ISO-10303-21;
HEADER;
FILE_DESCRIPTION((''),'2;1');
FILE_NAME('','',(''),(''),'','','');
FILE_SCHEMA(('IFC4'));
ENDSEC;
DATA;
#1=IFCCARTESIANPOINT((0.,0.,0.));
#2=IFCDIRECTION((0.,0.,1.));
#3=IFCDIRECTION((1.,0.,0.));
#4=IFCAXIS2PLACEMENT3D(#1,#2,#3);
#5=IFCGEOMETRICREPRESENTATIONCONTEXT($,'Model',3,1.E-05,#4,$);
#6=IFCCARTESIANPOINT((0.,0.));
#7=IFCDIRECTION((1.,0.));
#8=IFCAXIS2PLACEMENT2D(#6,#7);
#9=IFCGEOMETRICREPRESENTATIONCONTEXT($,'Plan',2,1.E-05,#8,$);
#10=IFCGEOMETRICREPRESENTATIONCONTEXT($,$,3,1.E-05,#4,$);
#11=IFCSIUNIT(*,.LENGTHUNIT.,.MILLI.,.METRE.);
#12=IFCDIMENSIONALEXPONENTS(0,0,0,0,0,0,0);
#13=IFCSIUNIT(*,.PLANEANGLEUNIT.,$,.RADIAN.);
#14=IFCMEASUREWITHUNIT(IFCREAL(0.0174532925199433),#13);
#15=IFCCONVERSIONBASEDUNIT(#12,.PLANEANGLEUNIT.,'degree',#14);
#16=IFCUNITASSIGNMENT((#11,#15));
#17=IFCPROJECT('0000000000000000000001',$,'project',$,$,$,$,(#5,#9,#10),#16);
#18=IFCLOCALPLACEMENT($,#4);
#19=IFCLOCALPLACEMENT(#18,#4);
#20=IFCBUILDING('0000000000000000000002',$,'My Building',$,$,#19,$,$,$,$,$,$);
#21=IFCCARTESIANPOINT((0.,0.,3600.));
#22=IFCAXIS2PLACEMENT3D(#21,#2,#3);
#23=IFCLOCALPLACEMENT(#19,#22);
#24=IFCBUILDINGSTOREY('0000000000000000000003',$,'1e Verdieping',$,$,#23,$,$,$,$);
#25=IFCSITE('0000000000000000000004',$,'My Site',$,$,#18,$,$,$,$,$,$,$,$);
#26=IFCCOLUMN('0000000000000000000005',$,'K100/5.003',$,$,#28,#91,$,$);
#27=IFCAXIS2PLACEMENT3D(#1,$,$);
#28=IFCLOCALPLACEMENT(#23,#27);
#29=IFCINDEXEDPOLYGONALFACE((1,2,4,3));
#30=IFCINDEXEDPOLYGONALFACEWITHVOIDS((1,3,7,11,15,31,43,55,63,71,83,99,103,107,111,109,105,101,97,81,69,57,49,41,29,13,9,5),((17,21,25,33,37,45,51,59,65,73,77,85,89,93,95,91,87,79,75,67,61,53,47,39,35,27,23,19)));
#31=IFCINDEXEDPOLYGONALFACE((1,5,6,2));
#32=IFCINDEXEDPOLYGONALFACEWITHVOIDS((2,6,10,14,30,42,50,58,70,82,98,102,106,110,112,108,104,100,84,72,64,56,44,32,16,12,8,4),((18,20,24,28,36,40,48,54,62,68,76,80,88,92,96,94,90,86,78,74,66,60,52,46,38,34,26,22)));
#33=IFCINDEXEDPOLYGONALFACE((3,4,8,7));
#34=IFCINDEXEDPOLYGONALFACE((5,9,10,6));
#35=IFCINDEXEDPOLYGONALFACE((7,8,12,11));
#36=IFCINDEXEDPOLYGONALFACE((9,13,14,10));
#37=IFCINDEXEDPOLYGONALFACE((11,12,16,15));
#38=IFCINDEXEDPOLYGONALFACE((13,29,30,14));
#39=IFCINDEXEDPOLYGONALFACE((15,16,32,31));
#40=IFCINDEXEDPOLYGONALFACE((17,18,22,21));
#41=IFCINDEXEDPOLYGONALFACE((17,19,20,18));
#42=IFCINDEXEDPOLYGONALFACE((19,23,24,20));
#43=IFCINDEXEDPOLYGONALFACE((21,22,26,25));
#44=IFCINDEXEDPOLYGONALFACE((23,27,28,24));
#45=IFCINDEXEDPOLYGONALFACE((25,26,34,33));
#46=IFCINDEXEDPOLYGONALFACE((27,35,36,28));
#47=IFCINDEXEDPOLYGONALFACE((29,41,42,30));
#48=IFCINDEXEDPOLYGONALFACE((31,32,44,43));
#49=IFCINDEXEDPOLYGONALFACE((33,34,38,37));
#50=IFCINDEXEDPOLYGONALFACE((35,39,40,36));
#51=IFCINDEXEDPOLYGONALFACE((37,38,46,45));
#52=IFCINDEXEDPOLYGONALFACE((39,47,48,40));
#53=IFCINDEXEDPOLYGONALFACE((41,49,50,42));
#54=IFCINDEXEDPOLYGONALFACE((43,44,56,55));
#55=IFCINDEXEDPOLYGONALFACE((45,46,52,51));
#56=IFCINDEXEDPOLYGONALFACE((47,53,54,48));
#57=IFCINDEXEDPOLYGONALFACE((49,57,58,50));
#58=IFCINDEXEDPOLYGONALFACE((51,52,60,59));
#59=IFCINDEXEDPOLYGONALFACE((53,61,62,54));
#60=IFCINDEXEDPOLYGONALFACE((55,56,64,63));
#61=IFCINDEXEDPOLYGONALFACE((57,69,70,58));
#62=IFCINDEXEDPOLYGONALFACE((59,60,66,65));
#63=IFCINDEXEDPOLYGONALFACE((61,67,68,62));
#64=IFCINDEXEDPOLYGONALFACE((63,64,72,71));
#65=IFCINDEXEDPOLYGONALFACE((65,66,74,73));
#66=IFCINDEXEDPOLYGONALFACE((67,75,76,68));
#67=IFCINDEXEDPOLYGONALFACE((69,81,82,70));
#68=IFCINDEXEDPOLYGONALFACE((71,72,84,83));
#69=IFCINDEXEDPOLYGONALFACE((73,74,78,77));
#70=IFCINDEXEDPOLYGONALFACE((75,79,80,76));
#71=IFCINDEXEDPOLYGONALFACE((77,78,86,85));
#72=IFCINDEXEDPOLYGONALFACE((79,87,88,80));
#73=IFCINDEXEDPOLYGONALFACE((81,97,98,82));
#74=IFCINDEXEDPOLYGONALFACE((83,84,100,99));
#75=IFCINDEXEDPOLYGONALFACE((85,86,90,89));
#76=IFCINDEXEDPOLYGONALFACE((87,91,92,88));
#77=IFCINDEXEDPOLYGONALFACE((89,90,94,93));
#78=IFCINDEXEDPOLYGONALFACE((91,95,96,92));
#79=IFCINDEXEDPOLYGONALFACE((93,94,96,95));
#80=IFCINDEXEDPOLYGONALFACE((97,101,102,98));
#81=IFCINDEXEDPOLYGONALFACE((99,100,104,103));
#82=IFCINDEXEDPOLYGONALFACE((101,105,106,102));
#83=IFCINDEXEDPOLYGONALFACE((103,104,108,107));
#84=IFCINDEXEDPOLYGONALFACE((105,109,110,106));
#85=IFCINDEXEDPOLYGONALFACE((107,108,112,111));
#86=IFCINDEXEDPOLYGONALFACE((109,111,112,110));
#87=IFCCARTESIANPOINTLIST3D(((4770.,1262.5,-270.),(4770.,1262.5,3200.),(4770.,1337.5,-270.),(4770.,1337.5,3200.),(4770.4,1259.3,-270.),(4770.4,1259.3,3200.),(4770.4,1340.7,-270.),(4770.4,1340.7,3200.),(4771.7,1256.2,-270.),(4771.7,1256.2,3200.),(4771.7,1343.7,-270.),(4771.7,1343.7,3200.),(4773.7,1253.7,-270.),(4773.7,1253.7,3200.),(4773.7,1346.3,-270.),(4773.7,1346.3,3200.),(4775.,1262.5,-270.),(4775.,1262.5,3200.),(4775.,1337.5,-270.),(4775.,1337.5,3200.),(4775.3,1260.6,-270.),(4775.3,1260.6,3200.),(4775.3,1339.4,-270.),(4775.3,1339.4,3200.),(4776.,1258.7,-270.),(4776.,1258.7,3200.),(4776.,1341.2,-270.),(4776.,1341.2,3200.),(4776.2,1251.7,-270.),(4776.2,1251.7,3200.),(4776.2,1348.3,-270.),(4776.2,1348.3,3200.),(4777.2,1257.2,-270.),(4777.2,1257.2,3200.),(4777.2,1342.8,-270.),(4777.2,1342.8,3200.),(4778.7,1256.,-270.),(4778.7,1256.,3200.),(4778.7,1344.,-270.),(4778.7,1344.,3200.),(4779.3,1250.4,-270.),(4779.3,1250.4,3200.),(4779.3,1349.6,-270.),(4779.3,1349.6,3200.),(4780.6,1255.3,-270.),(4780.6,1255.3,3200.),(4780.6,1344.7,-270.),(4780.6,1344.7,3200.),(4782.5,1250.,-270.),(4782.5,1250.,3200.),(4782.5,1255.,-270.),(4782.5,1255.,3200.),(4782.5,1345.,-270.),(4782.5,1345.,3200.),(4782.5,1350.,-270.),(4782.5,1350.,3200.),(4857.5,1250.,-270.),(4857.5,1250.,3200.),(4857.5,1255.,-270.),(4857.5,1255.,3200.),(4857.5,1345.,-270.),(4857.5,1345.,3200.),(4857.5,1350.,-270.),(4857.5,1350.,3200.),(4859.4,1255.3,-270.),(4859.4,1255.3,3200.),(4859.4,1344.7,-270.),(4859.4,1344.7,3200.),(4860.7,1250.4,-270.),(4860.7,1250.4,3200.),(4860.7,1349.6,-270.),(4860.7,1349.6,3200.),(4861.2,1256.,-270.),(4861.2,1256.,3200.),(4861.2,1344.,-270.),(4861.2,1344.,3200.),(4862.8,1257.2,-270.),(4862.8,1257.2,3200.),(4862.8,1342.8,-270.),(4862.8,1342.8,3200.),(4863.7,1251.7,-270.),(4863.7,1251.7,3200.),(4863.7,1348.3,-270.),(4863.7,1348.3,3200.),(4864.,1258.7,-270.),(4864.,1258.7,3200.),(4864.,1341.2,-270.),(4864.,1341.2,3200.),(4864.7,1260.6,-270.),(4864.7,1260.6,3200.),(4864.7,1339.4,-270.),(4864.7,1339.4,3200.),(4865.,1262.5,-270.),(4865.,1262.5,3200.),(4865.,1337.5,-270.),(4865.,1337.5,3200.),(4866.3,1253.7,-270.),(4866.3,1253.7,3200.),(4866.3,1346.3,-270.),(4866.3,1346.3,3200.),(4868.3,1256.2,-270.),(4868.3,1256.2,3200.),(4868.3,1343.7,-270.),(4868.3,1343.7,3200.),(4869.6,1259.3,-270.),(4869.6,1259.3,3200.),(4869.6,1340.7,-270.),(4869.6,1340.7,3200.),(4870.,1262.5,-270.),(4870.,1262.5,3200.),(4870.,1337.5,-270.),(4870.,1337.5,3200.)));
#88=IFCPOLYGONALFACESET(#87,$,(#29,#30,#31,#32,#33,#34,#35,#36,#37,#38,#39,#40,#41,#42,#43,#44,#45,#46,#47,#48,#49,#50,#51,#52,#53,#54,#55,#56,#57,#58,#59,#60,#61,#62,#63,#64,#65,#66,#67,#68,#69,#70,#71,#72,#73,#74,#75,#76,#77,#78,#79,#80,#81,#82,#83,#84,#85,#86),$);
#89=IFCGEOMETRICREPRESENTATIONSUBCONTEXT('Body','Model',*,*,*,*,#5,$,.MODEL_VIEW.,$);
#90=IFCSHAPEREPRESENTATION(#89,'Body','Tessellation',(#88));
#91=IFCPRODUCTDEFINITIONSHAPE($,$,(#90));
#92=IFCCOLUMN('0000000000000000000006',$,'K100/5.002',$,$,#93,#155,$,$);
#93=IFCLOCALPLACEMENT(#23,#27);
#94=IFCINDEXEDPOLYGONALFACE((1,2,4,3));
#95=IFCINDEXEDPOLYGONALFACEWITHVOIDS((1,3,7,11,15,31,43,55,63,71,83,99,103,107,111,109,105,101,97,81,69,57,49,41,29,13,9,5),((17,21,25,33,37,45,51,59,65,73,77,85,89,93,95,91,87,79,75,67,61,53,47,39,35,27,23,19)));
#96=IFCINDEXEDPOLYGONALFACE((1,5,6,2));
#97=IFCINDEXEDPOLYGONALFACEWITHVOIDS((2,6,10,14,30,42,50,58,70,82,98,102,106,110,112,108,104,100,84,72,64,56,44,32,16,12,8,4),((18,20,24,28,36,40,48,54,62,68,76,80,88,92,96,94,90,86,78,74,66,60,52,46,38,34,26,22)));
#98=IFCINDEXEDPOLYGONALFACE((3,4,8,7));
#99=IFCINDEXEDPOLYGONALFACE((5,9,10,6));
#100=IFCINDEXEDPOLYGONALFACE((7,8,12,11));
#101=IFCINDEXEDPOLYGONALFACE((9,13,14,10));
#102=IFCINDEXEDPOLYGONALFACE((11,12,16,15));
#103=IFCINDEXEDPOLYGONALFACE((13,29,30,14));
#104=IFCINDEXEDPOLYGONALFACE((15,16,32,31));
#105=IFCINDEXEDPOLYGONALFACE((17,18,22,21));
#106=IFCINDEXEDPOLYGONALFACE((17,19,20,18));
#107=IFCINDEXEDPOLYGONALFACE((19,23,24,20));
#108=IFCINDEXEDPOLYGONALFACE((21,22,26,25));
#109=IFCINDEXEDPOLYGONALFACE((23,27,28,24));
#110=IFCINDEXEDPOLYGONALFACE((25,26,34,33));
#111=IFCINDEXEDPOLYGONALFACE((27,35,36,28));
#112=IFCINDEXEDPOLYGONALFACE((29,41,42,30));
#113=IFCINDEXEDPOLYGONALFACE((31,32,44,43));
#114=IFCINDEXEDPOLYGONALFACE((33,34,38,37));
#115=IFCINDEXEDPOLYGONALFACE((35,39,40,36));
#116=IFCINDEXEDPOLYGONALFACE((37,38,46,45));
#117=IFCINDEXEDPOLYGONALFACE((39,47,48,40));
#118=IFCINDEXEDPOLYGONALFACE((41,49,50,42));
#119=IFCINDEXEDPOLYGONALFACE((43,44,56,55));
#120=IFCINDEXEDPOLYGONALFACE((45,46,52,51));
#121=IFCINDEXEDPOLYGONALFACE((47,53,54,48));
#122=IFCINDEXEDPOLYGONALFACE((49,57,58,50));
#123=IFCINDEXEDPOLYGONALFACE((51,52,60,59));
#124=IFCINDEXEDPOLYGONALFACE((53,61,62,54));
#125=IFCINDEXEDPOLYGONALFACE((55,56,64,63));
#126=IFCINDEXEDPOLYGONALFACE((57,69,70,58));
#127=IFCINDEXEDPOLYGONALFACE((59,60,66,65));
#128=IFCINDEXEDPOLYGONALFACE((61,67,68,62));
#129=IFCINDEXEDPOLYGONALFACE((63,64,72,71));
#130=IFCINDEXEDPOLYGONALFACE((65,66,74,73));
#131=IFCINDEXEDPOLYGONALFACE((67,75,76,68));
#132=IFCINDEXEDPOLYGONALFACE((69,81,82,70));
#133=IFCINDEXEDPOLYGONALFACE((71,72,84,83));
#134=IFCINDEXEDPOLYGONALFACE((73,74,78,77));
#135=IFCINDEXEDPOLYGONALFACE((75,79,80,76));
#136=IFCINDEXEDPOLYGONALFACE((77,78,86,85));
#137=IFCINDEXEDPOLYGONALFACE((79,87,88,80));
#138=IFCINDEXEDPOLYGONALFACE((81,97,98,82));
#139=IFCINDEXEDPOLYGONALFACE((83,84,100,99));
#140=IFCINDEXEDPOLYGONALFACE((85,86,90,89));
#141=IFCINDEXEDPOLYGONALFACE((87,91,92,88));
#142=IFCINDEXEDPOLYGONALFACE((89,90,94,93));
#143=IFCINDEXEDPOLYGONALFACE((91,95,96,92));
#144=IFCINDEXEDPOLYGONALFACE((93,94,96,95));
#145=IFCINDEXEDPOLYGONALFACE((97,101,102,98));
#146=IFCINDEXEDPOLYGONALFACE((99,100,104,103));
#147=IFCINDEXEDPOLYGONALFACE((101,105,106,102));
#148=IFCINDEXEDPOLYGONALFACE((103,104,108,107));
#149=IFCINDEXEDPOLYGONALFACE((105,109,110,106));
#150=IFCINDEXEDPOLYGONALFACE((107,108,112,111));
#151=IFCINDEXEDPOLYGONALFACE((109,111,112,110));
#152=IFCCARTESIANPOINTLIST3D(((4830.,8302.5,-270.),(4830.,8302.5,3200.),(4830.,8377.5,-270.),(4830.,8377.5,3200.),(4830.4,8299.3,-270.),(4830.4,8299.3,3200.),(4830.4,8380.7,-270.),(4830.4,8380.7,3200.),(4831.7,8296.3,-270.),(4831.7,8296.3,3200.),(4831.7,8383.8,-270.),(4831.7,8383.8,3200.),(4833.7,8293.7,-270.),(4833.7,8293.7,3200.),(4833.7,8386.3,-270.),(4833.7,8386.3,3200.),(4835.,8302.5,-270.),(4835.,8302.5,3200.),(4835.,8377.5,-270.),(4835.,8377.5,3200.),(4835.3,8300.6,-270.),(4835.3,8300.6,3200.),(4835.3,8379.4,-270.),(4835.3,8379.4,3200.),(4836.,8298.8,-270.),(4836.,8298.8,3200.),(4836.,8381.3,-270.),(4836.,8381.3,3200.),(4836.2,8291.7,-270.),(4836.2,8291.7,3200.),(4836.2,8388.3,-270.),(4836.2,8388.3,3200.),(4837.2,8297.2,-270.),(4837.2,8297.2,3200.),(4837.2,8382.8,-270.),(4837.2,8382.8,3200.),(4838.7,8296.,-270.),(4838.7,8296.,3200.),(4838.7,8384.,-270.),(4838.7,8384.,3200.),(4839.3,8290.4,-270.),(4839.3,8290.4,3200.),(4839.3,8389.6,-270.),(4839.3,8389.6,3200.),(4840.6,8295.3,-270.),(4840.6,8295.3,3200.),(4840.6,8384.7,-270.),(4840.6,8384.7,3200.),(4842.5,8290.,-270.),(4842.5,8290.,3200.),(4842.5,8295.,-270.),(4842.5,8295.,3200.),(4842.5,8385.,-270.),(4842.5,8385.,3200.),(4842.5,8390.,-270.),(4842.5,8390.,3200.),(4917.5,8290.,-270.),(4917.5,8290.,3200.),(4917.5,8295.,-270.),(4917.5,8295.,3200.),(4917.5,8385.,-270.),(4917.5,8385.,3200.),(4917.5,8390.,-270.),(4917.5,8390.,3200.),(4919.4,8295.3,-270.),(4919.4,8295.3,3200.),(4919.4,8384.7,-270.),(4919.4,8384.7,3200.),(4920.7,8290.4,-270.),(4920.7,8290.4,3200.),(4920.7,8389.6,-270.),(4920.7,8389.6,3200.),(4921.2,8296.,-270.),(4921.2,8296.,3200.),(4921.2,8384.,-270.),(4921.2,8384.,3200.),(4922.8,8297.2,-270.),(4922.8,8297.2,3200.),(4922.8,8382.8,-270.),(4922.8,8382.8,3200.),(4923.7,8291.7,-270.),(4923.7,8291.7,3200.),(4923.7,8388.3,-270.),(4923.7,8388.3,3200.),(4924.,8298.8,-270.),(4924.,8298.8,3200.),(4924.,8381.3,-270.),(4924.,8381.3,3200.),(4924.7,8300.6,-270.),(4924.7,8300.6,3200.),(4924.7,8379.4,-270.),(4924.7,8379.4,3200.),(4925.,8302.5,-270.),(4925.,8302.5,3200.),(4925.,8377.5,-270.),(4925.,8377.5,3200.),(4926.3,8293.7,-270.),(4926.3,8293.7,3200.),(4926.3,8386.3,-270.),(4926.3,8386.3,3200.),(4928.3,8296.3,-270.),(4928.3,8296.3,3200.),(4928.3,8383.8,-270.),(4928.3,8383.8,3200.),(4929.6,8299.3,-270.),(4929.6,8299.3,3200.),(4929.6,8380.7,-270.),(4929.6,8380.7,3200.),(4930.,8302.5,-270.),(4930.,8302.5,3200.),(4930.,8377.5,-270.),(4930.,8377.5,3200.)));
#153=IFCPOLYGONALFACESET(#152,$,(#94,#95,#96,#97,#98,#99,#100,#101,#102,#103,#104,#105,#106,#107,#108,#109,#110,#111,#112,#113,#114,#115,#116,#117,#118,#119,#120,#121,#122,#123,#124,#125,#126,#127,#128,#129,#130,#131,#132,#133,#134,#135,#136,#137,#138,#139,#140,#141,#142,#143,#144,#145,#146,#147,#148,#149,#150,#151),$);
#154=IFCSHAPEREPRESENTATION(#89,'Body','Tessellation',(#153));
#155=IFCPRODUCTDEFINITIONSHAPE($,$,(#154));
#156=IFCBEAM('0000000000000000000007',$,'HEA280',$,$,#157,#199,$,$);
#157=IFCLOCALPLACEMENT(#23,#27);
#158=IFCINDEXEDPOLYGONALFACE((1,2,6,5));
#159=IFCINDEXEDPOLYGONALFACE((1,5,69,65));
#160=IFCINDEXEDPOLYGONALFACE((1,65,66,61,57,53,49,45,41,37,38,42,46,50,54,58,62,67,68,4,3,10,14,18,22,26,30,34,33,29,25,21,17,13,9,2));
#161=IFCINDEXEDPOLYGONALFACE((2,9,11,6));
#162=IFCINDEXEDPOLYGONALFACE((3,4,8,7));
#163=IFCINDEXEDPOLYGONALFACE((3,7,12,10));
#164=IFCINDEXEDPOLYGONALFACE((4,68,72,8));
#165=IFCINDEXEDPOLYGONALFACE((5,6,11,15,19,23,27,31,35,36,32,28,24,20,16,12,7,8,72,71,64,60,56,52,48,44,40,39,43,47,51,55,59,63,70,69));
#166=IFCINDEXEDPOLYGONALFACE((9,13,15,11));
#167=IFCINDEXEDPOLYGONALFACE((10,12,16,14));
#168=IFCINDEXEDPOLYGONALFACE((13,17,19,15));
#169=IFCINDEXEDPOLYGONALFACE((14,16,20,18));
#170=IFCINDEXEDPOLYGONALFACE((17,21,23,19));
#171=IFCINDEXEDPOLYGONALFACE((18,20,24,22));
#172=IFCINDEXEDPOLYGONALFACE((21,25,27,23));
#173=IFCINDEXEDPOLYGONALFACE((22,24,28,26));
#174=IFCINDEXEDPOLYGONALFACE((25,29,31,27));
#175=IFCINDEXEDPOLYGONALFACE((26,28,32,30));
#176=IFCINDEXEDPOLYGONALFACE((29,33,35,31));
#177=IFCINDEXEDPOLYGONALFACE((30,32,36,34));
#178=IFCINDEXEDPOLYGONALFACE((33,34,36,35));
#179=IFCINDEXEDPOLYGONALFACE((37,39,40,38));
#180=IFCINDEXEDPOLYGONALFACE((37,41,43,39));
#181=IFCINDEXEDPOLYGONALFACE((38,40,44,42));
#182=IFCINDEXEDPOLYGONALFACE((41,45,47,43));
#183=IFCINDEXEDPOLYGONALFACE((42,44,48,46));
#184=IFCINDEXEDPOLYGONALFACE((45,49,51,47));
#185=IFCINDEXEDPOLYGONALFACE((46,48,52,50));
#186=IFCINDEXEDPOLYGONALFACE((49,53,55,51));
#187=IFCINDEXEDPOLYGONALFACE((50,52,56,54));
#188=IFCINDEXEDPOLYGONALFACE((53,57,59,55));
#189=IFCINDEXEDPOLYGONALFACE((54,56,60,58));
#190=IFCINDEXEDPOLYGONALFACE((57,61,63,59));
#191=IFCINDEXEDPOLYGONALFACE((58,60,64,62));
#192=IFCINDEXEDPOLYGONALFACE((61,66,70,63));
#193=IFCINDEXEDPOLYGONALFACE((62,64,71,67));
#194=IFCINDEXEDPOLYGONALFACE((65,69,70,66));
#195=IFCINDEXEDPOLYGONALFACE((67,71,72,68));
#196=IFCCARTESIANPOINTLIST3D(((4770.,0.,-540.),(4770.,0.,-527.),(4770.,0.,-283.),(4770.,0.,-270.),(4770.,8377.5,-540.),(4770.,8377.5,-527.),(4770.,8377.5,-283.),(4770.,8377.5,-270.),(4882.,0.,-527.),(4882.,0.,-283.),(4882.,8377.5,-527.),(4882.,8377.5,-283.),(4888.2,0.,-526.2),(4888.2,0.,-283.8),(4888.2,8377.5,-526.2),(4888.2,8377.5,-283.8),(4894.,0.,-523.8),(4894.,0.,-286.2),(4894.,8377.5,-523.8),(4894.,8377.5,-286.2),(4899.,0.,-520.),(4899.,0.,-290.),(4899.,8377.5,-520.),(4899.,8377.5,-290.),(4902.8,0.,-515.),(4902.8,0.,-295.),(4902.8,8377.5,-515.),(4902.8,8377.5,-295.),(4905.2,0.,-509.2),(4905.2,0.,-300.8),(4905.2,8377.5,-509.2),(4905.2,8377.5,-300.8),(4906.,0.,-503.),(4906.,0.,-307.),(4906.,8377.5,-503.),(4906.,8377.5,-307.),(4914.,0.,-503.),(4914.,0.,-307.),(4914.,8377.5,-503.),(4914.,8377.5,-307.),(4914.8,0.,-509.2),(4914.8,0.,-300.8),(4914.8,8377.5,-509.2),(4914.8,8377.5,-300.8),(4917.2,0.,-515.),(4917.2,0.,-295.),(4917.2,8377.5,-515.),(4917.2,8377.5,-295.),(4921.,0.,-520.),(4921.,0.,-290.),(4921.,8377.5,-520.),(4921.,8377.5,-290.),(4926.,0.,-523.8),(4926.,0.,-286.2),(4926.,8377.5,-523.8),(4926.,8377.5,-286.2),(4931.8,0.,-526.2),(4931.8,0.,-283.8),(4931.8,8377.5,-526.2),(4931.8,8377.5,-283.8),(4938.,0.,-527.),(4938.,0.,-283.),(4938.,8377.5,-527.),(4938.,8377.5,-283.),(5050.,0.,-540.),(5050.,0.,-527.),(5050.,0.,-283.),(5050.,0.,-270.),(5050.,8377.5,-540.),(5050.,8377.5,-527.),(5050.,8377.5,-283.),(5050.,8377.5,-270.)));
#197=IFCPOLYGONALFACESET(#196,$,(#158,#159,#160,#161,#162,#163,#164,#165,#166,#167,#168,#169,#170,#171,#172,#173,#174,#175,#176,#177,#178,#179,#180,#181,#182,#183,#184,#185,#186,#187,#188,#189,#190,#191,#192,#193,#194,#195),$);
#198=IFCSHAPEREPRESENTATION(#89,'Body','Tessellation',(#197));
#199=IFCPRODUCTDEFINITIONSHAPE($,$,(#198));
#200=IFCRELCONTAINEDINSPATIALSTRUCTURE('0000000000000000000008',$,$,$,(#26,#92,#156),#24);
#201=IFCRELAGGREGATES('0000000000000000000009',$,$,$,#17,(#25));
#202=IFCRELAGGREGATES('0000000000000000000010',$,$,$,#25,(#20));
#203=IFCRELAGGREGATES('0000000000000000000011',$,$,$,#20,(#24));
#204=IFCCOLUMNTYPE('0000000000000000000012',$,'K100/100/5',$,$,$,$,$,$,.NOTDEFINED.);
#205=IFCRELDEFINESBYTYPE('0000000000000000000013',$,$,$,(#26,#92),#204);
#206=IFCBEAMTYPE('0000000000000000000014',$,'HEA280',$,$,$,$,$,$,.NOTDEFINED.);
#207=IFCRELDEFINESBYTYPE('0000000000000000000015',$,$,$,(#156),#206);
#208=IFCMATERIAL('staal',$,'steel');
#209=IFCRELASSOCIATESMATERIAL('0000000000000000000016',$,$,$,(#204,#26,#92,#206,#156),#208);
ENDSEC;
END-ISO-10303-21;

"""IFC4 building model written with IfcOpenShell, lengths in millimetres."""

from ifc_helpers import new_model, entity, si_unit, converted_unit, frame, origin_with_axes, origin_2d_with_axis, place, context, subcontext, project, spatial, hollow_rectangle, i_section, extrude, material, material_profile, profile_set, profile_usage, type_object, element, save


model = new_model("IFC4")

# Units and contexts
model_context = context("Model", 3, precision=1e-05, world=origin_with_axes())
plan_context = context("Plan", 2, precision=1e-05, world=origin_2d_with_axis())
context_of_model = context(None, 3, precision=1e-05, world=origin_with_axes())
body_context = subcontext(model_context, "Body", "Model", "MODEL_VIEW")
ifc_project = project(units=[si_unit("LENGTHUNIT", "METRE", prefix="MILLI"), converted_unit("PLANEANGLEUNIT", "degree", entity("IfcReal", 0.0174532925199433), si_unit("PLANEANGLEUNIT", "RADIAN"), dimensions=[0, 0, 0, 0, 0, 0, 0])], contexts=[model_context, plan_context, context_of_model])

# Site, building, storey
site_placement = place(None, origin_with_axes())
site = spatial("IfcSite", under=ifc_project, at=site_placement, Name="My Site")
building_placement = place(site_placement, origin_with_axes())
building = spatial("IfcBuilding", under=site, at=building_placement, Name="My Building")
storey_placement = place(building_placement, frame((0.0, 0.0, 3600.0), z_axis=(0.0, 0.0, 1.0), x_axis=(1.0, 0.0, 0.0)))
storey = spatial("IfcBuildingStorey", under=building, at=storey_placement, Name="1e Verdieping")

# Shared definitions
ifc_material = material(Name="staal", Category="steel")

# Columns
ifc_material_profile_1 = material_profile(ifc_material, hollow_rectangle(XDim=100.0, YDim=100.0, WallThickness=5.0, InnerFilletRadius=7.5, OuterFilletRadius=12.5))
ifc_profile_set_1 = profile_set([ifc_material_profile_1], Name="K100/100/5")
ifc_profile_usage_1 = profile_usage(ifc_profile_set_1, cardinal=5)
column_type_1 = type_object("IfcColumnType", Name="K100/100/5", PredefinedType="NOTDEFINED", material=ifc_profile_set_1)
column_1_placement = place(storey_placement, frame((4820.0, 1300.0, -270.0), z_axis=(0.0, 0.0, 1.0), x_axis=(1.0, 0.0, 0.0)))
element("IfcColumn", 1, at=column_1_placement, inside=storey, type_object=column_type_1, material=ifc_profile_usage_1, Name="K100/5.003", context=body_context, shape_type="SweptSolid", body=[
    extrude(hollow_rectangle(XDim=100.0, YDim=100.0, WallThickness=5.0, InnerFilletRadius=7.5, OuterFilletRadius=12.5), origin_with_axes(), (0.0, 0.0, 1.0), 3470.0),
])
ifc_profile_usage_2 = profile_usage(ifc_profile_set_1, cardinal=5)
column_2_placement = place(storey_placement, frame((4880.0, 8340.0, -270.0), z_axis=(0.0, 0.0, 1.0), x_axis=(1.0, 0.0, 0.0)))
element("IfcColumn", 2, at=column_2_placement, inside=storey, type_object=column_type_1, material=ifc_profile_usage_2, Name="K100/5.002", context=body_context, shape_type="SweptSolid", body=[
    extrude(hollow_rectangle(XDim=100.0, YDim=100.0, WallThickness=5.0, InnerFilletRadius=7.5, OuterFilletRadius=12.5), origin_with_axes(), (0.0, 0.0, 1.0), 3470.0),
])

# Beam
ifc_material_profile_2 = material_profile(ifc_material, i_section(OverallWidth=280.0, OverallDepth=270.0, WebThickness=8.0, FlangeThickness=13.0, FilletRadius=24.0))
ifc_profile_set_2 = profile_set([ifc_material_profile_2], Name="HEA280")
ifc_profile_usage_3 = profile_usage(ifc_profile_set_2)
beam_type_1 = type_object("IfcBeamType", Name="HEA280", PredefinedType="NOTDEFINED", material=ifc_profile_set_2)
beam_1_placement = place(storey_placement, frame((4910.0, 0.0, -405.0), z_axis=(0.0, 1.0, 0.0), x_axis=(-1.0, 0.0, 0.0)))
element("IfcBeam", 3, at=beam_1_placement, inside=storey, type_object=beam_type_1, material=ifc_profile_usage_3, Name="HEA280", context=body_context, shape_type="SweptSolid", body=[
    extrude(i_section(OverallWidth=280.0, OverallDepth=270.0, WebThickness=8.0, FlangeThickness=13.0, FilletRadius=24.0), origin_with_axes(), (0.0, 0.0, 1.0), 8377.5),
])

save(model, "model.ifc")
